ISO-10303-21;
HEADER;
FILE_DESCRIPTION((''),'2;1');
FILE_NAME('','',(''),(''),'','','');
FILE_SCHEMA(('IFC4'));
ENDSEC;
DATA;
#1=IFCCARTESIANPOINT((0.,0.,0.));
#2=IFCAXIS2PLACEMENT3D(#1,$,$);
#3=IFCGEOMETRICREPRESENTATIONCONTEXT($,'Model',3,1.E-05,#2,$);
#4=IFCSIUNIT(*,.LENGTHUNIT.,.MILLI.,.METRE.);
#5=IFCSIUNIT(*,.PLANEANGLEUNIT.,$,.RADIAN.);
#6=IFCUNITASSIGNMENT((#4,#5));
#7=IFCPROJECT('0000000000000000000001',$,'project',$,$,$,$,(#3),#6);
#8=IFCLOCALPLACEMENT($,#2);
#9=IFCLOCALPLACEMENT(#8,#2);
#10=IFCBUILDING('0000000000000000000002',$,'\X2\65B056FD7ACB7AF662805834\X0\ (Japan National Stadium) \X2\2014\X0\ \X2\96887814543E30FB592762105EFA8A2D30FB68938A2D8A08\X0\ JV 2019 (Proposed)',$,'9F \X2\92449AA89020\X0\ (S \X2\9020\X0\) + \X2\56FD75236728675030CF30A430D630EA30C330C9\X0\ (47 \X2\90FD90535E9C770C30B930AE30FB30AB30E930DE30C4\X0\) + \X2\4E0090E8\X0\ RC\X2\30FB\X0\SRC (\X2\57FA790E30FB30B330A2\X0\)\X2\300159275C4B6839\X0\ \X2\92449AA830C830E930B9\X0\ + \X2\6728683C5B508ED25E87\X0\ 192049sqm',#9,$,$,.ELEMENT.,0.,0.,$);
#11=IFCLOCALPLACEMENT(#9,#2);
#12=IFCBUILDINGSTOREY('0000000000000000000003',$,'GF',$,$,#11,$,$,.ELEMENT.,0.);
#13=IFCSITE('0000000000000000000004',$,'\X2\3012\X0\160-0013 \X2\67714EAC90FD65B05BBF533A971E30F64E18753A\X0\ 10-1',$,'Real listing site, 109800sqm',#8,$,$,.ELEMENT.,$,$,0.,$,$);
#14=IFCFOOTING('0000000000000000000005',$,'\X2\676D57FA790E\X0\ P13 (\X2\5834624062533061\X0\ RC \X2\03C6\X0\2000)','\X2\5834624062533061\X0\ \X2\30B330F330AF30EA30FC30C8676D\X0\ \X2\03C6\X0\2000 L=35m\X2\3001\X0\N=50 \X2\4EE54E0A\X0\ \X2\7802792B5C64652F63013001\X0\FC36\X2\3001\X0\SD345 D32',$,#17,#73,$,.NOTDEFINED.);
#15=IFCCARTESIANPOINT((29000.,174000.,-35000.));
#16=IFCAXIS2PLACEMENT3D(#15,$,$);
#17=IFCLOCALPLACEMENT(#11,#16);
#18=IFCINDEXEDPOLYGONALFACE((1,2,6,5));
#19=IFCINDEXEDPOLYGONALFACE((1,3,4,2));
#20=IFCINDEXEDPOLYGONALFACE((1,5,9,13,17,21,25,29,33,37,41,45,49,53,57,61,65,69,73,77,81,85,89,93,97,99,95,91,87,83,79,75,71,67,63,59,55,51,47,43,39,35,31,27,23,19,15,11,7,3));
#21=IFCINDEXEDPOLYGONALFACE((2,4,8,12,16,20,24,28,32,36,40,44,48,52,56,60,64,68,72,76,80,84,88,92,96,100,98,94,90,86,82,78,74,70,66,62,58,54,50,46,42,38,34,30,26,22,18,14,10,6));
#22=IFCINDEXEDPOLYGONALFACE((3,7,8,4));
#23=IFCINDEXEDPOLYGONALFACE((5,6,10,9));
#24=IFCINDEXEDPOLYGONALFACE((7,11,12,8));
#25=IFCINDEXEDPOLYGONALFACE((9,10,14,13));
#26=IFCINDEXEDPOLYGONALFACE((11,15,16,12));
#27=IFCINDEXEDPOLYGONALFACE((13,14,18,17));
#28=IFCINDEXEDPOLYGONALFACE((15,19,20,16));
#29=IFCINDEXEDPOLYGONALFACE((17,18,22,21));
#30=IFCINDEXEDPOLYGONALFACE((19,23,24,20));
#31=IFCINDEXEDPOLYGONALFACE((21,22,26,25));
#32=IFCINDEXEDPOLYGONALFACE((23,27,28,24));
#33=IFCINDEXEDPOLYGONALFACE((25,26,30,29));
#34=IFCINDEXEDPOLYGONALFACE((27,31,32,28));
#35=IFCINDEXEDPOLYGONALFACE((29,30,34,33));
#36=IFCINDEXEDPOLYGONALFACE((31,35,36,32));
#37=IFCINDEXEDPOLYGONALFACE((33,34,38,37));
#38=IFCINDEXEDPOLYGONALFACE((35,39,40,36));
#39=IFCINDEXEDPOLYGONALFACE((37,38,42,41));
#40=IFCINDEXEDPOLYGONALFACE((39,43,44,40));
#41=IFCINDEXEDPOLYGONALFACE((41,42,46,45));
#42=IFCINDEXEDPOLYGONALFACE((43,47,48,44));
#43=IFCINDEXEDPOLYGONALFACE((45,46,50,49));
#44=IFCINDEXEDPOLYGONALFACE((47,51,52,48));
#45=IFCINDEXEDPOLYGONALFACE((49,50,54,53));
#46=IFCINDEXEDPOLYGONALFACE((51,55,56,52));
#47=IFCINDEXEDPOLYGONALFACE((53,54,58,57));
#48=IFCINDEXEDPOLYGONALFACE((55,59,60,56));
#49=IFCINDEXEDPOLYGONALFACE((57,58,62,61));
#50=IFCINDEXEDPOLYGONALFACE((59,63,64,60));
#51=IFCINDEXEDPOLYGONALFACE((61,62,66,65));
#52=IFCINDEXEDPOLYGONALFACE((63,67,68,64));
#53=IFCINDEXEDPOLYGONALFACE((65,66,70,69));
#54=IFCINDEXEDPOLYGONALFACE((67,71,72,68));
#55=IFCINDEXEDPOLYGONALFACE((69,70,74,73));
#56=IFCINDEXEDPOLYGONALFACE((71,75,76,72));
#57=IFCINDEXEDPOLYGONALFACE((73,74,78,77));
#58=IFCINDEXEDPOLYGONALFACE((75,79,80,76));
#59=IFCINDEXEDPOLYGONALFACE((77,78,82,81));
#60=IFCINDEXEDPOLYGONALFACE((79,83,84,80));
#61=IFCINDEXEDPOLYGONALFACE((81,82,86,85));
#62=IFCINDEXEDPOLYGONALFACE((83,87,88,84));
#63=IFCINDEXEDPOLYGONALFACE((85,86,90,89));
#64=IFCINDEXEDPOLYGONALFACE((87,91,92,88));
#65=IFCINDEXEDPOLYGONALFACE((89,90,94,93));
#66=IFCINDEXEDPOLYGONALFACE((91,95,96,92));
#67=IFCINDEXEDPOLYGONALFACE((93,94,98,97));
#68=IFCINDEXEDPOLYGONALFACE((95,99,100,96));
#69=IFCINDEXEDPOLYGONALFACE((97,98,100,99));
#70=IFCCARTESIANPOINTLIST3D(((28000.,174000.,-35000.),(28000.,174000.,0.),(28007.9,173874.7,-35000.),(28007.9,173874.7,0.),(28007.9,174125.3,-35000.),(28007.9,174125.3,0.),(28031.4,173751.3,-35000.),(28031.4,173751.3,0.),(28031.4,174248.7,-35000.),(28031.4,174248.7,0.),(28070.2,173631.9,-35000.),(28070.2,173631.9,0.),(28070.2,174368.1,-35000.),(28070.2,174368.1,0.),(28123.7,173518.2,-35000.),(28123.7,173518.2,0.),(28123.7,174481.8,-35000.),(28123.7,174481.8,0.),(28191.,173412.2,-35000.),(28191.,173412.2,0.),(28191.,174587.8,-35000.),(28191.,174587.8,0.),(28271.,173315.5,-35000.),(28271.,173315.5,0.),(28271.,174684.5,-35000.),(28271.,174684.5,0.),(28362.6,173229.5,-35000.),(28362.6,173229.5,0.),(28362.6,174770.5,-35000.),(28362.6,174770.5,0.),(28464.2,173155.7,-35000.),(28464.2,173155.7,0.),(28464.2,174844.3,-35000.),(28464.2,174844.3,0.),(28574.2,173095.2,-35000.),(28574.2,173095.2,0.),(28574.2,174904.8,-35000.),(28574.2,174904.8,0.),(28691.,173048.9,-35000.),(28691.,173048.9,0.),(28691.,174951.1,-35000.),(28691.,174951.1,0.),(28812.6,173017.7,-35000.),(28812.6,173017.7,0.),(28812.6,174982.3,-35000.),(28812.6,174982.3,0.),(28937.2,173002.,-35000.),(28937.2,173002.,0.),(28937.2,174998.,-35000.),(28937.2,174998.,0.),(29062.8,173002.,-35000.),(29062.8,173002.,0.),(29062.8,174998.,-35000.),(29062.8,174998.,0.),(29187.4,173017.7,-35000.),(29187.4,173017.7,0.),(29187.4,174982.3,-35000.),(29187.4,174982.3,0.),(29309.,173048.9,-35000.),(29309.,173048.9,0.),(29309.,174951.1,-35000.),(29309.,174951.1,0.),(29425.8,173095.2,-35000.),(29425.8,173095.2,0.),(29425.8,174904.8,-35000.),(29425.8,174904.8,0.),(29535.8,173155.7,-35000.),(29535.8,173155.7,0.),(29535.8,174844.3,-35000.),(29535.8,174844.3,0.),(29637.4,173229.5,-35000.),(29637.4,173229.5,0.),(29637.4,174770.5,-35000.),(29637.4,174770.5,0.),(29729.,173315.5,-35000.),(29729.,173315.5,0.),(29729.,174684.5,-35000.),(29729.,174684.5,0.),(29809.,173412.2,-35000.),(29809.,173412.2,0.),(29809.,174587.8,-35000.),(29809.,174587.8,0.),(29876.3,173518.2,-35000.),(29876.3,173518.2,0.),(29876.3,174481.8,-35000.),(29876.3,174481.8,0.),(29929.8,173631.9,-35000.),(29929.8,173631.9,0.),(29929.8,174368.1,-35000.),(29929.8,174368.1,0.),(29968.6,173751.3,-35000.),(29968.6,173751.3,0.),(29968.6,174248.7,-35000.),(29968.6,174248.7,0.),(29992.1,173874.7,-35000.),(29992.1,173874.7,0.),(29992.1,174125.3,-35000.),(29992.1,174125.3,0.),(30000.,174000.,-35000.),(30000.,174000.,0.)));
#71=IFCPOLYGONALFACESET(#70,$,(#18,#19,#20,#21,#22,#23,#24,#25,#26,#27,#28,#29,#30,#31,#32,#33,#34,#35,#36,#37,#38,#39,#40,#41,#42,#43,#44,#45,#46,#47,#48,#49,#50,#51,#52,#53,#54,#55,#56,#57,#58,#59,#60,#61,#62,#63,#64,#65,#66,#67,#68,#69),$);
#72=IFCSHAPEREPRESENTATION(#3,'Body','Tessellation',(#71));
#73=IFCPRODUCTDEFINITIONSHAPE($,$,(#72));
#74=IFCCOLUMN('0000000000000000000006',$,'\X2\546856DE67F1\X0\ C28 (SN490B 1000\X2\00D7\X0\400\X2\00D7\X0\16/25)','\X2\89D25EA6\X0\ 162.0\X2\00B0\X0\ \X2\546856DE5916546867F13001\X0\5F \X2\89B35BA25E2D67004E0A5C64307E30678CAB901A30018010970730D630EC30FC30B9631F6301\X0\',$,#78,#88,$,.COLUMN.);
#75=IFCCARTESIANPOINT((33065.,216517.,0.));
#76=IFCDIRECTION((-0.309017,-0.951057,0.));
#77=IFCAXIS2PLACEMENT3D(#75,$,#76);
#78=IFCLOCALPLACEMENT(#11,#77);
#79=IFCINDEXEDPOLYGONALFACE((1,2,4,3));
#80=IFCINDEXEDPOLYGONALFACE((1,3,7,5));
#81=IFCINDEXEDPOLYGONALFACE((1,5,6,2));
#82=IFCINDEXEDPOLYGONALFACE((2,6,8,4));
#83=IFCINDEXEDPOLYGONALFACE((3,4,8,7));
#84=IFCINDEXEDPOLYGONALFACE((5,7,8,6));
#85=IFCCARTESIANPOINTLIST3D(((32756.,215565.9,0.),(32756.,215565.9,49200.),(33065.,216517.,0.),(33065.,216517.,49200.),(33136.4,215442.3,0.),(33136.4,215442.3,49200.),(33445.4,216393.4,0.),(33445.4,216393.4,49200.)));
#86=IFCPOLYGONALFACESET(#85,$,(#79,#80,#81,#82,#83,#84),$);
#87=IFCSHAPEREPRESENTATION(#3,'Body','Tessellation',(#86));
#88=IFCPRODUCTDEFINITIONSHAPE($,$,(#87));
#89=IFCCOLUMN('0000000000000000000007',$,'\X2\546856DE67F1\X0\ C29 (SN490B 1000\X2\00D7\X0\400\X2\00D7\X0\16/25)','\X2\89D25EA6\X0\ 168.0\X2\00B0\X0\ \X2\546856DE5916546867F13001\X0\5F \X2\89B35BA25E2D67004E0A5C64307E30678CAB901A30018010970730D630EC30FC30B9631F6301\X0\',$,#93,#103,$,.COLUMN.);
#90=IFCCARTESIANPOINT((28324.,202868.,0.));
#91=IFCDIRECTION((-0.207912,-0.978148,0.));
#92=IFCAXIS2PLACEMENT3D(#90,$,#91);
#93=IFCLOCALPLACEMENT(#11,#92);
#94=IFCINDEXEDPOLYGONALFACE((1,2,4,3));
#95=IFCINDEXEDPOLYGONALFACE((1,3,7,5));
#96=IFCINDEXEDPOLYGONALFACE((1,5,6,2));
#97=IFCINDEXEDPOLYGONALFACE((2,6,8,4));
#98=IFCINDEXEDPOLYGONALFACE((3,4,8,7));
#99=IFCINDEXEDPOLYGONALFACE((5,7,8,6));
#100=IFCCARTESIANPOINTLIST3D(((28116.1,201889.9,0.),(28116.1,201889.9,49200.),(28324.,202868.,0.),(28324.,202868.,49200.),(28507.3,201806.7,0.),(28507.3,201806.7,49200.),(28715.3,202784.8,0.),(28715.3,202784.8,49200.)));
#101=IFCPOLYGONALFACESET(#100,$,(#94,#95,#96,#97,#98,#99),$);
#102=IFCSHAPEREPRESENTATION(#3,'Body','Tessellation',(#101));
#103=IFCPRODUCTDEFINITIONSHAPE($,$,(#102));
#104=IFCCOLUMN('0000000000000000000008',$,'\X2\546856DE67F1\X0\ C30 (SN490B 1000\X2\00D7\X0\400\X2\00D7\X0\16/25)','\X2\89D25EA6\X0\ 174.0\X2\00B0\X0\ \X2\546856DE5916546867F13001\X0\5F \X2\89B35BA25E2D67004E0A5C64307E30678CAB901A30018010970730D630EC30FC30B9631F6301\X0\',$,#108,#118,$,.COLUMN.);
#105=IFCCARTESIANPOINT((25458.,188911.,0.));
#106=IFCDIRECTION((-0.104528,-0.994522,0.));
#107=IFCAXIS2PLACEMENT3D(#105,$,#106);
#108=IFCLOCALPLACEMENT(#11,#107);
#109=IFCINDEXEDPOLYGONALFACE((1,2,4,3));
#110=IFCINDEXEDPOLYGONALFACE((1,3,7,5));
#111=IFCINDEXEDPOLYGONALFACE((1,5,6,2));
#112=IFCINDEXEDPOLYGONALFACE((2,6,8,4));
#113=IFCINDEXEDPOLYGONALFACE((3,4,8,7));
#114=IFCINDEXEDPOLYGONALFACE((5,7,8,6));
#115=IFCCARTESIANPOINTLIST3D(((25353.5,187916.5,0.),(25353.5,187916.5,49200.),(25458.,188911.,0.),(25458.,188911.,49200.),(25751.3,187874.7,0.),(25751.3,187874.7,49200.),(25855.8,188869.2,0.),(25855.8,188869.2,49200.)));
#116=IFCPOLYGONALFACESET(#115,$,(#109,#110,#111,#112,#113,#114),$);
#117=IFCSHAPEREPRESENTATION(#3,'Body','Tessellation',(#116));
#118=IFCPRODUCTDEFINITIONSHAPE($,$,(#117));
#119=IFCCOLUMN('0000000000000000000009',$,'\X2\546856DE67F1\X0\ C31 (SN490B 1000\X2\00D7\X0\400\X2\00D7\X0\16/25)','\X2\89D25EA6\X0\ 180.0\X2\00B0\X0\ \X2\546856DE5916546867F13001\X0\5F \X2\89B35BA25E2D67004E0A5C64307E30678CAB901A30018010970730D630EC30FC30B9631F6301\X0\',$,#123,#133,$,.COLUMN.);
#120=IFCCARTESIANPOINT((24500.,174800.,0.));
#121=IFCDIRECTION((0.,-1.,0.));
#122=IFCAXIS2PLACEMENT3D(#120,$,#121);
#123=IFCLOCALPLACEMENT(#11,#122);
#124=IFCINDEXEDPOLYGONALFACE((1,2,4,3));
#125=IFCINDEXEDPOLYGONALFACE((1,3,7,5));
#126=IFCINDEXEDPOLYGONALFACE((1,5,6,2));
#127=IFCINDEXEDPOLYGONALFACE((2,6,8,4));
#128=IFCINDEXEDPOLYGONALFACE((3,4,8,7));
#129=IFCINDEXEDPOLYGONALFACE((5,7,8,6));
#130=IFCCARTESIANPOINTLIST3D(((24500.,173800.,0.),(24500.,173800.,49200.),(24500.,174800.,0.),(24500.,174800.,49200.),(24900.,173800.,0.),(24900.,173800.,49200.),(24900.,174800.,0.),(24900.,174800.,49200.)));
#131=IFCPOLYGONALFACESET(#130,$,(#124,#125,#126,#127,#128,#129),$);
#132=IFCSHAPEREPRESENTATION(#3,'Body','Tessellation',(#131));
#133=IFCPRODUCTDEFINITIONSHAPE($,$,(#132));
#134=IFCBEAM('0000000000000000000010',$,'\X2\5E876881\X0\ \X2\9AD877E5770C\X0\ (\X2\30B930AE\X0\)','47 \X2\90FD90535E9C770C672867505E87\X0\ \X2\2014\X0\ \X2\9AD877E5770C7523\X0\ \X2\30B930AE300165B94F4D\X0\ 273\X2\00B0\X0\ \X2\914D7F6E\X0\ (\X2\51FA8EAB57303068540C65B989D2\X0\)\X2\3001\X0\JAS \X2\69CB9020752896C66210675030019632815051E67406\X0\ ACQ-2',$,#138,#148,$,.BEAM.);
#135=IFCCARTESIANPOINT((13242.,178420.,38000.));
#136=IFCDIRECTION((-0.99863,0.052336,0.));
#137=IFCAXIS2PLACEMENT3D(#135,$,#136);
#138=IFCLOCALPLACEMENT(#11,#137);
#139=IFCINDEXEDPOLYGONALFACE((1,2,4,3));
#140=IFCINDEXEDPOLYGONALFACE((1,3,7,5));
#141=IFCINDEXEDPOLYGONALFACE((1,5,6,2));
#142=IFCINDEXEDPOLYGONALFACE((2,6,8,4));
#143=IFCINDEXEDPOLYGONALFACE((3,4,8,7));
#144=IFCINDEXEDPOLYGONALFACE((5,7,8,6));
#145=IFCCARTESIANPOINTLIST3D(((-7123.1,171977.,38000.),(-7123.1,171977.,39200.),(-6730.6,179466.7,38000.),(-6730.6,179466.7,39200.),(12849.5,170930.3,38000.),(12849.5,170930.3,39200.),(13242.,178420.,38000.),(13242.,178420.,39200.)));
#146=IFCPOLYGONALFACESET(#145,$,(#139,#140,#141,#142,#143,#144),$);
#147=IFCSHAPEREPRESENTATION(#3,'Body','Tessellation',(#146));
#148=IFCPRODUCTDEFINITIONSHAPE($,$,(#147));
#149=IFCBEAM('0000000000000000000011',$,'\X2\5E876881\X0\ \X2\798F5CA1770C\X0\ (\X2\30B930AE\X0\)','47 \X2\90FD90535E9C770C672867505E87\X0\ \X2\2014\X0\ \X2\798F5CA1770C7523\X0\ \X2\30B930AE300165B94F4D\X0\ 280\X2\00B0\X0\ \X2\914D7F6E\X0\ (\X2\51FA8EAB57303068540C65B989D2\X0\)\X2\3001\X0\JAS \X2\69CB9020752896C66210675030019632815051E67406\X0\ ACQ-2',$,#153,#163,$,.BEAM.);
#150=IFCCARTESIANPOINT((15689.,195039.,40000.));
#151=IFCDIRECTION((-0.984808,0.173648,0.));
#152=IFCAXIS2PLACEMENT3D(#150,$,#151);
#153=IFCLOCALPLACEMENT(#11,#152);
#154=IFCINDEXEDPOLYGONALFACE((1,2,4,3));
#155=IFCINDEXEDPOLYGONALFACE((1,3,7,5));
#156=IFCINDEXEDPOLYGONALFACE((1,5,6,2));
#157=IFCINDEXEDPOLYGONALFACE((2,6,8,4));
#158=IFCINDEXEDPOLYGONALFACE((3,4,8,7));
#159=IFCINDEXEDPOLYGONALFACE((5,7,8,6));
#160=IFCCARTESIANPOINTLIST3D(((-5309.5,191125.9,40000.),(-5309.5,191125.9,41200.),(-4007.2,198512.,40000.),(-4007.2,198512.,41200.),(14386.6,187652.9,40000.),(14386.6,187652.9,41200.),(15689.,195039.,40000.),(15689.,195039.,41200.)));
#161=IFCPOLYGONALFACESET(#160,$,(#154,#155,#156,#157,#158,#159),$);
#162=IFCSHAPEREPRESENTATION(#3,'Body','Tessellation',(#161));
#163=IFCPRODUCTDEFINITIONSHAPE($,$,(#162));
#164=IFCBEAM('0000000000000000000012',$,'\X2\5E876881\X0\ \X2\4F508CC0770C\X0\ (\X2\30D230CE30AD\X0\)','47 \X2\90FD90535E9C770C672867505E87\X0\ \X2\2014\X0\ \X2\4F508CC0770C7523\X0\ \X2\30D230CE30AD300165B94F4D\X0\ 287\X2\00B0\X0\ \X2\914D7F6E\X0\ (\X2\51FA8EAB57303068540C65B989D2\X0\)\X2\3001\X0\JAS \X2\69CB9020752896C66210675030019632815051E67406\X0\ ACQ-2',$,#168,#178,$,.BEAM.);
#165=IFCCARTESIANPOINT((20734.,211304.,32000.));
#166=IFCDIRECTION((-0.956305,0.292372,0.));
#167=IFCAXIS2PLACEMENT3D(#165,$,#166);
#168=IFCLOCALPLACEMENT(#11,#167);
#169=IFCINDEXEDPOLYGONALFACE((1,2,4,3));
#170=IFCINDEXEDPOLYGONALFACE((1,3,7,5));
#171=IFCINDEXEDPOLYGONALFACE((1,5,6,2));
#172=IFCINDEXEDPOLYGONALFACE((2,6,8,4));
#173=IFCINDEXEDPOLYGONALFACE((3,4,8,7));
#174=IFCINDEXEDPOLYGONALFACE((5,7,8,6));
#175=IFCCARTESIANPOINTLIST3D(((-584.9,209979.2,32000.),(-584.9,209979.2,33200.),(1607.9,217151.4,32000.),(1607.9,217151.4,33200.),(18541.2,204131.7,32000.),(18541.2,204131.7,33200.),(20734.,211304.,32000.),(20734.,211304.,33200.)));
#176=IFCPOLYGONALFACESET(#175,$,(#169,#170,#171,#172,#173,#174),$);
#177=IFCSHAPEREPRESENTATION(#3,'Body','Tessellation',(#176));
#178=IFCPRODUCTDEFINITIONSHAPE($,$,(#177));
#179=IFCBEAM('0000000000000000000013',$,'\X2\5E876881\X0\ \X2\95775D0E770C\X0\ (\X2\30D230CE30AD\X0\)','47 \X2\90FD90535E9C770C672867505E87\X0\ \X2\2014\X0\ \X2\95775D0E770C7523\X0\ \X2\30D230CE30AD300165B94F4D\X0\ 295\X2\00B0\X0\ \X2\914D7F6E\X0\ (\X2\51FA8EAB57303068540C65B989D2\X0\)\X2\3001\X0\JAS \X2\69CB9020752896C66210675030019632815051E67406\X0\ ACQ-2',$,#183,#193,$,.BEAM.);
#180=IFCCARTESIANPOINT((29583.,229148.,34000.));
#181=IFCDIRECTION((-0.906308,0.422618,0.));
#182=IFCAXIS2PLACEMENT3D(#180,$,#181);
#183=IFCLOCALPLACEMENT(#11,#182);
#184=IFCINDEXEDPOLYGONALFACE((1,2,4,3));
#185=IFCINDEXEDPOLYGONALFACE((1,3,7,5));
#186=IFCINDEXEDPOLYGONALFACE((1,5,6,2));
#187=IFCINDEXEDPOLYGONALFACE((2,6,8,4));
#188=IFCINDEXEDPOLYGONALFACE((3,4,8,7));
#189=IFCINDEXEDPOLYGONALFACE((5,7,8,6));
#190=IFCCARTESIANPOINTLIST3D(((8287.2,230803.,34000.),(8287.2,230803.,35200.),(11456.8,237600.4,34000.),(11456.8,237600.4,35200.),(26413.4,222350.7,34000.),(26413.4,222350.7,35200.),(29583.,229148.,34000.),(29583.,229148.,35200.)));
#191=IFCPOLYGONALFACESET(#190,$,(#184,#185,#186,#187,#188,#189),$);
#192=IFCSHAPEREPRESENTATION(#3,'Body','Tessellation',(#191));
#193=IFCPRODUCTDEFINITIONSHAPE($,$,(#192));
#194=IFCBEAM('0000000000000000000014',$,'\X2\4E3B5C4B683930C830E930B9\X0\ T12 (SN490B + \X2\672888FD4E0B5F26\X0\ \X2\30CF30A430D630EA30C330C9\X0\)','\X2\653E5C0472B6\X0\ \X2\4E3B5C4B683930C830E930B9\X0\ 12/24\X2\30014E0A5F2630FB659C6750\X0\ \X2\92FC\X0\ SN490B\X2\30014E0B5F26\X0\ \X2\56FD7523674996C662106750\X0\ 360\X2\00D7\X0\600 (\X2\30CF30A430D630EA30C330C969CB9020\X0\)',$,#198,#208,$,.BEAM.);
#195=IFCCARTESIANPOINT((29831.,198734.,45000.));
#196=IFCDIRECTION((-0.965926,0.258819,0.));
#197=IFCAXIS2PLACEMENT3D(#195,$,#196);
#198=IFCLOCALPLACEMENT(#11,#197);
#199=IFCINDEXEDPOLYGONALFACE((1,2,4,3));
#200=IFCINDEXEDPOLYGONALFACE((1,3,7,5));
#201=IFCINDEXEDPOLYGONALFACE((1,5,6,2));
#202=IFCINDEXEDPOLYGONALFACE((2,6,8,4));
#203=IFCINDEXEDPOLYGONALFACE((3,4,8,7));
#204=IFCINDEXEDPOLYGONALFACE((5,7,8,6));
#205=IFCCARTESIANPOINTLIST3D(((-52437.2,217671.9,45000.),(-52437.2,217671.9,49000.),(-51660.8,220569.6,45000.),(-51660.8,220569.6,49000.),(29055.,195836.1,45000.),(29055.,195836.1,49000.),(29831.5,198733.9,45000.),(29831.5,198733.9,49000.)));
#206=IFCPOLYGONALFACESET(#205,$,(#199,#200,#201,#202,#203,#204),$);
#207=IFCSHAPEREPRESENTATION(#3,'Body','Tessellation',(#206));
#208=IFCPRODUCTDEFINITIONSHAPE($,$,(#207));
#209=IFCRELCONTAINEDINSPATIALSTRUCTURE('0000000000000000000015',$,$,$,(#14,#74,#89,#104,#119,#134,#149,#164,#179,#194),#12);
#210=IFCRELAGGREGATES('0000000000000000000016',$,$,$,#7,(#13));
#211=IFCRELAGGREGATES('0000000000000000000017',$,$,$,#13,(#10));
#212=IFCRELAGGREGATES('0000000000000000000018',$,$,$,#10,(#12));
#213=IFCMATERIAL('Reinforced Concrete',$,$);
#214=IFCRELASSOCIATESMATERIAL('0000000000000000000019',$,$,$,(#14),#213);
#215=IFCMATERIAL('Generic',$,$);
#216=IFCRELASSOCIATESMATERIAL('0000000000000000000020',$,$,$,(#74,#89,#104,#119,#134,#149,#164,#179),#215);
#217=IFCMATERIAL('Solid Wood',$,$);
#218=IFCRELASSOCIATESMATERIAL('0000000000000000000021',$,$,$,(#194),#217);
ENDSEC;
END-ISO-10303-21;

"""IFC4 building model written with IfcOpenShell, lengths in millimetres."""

from ifc_helpers import new_model, si_unit, frame, frame_2d, origin, origin_2d, place, context, project, spatial, rectangle, circle, extrude, material, element, save


model = new_model("IFC4")

# Units and contexts
model_context = context("Model", 3, precision=1e-05, world=origin())
ifc_project = project(units=[si_unit("LENGTHUNIT", "METRE", prefix="MILLI"), si_unit("PLANEANGLEUNIT", "RADIAN")], contexts=[model_context])

# Site, building, storey
site_placement = place(None, origin())
site = spatial("IfcSite", under=ifc_project, at=site_placement, Name="〒160-0013 東京都新宿区霞ヶ丘町 10-1", ObjectType="Real listing site, 109800sqm", CompositionType="ELEMENT", RefElevation=0.0)
building_placement = place(site_placement, origin())
building = spatial("IfcBuilding", under=site, at=building_placement, Name="新国立競技場 (Japan National Stadium) — 隈研吾・大成建設・梓設計 JV 2019 (Proposed)", ObjectType="9F 鉄骨造 (S 造) + 国産木材ハイブリッド (47 都道府県スギ・カラマツ) + 一部 RC・SRC (基礎・コア)、大屋根 鉄骨トラス + 木格子軒庇 192049sqm", CompositionType="ELEMENT", ElevationOfRefHeight=0.0, ElevationOfTerrain=0.0)
storey_placement = place(building_placement, origin())
storey = spatial("IfcBuildingStorey", under=building, at=storey_placement, Name="GF", CompositionType="ELEMENT", Elevation=0.0)

# Footing
ifc_material_1 = material(Name="Reinforced Concrete")
footing_placement = place(storey_placement, frame((29000.0, 174000.0, -35000.0)))
element("IfcFooting", 1, at=footing_placement, inside=storey, material=ifc_material_1, Name="杭基礎 P13 (場所打ち RC φ2000)", Description="場所打ち コンクリート杭 φ2000 L=35m、N=50 以上 砂礫層支持、FC36、SD345 D32", PredefinedType="NOTDEFINED", context=model_context, shape_type="SweptSolid", body=[
    extrude(circle(Radius=1000.0, at=origin_2d()), frame((29000.0, 174000.0, -35000.0)), (0.0, 0.0, 1.0), 35000.0),
])

# Columns
ifc_material_2 = material(Name="Generic")
column_1_placement = place(storey_placement, frame((33065.0, 216517.0, 0.0), x_axis=(-0.309017, -0.951057, 0.0)))
element("IfcColumn", 2, at=column_1_placement, inside=storey, material=ifc_material_2, Name="周回柱 C28 (SN490B 1000×400×16/25)", Description="角度 162.0° 周回外周柱、5F 観客席最上層まで貫通、耐震ブレース挟持", PredefinedType="COLUMN", context=model_context, shape_type="SweptSolid", body=[
    extrude(rectangle(XDim=1000.0, YDim=400.0, at=frame_2d((500.0, 200.0))), frame((33065.0, 216517.0, 0.0), x_axis=(-0.309017, -0.951057, 0.0)), (0.0, 0.0, 1.0), 49200.0),
])
column_2_placement = place(storey_placement, frame((28324.0, 202868.0, 0.0), x_axis=(-0.207912, -0.978148, 0.0)))
element("IfcColumn", 3, at=column_2_placement, inside=storey, material=ifc_material_2, Name="周回柱 C29 (SN490B 1000×400×16/25)", Description="角度 168.0° 周回外周柱、5F 観客席最上層まで貫通、耐震ブレース挟持", PredefinedType="COLUMN", context=model_context, shape_type="SweptSolid", body=[
    extrude(rectangle(XDim=1000.0, YDim=400.0, at=frame_2d((500.0, 200.0))), frame((28324.0, 202868.0, 0.0), x_axis=(-0.207912, -0.978148, 0.0)), (0.0, 0.0, 1.0), 49200.0),
])
column_3_placement = place(storey_placement, frame((25458.0, 188911.0, 0.0), x_axis=(-0.104528, -0.994522, 0.0)))
element("IfcColumn", 4, at=column_3_placement, inside=storey, material=ifc_material_2, Name="周回柱 C30 (SN490B 1000×400×16/25)", Description="角度 174.0° 周回外周柱、5F 観客席最上層まで貫通、耐震ブレース挟持", PredefinedType="COLUMN", context=model_context, shape_type="SweptSolid", body=[
    extrude(rectangle(XDim=1000.0, YDim=400.0, at=frame_2d((500.0, 200.0))), frame((25458.0, 188911.0, 0.0), x_axis=(-0.104528, -0.994522, 0.0)), (0.0, 0.0, 1.0), 49200.0),
])
column_4_placement = place(storey_placement, frame((24500.0, 174800.0, 0.0), x_axis=(0.0, -1.0, 0.0)))
element("IfcColumn", 5, at=column_4_placement, inside=storey, material=ifc_material_2, Name="周回柱 C31 (SN490B 1000×400×16/25)", Description="角度 180.0° 周回外周柱、5F 観客席最上層まで貫通、耐震ブレース挟持", PredefinedType="COLUMN", context=model_context, shape_type="SweptSolid", body=[
    extrude(rectangle(XDim=1000.0, YDim=400.0, at=frame_2d((500.0, 200.0))), frame((24500.0, 174800.0, 0.0), x_axis=(0.0, -1.0, 0.0)), (0.0, 0.0, 1.0), 49200.0),
])

# Beams
beam_1_placement = place(storey_placement, frame((13242.0, 178420.0, 38000.0), x_axis=(-0.99863, 0.052336, 0.0)))
element("IfcBeam", 6, at=beam_1_placement, inside=storey, material=ifc_material_2, Name="庇梁 高知県 (スギ)", Description="47 都道府県木材庇 — 高知県産 スギ、方位 273° 配置 (出身地と同方角)、JAS 構造用集成材、防腐処理 ACQ-2", PredefinedType="BEAM", context=model_context, shape_type="SweptSolid", body=[
    extrude(rectangle(XDim=20000.0, YDim=7500.0, at=frame_2d((10000.0, 3750.0))), frame((13242.0, 178420.0, 38000.0), x_axis=(-0.99863, 0.052336, 0.0)), (0.0, 0.0, 1.0), 1200.0),
])
beam_2_placement = place(storey_placement, frame((15689.0, 195039.0, 40000.0), x_axis=(-0.984808, 0.173648, 0.0)))
element("IfcBeam", 7, at=beam_2_placement, inside=storey, material=ifc_material_2, Name="庇梁 福岡県 (スギ)", Description="47 都道府県木材庇 — 福岡県産 スギ、方位 280° 配置 (出身地と同方角)、JAS 構造用集成材、防腐処理 ACQ-2", PredefinedType="BEAM", context=model_context, shape_type="SweptSolid", body=[
    extrude(rectangle(XDim=20000.0, YDim=7500.0, at=frame_2d((10000.0, 3750.0))), frame((15689.0, 195039.0, 40000.0), x_axis=(-0.984808, 0.173648, 0.0)), (0.0, 0.0, 1.0), 1200.0),
])
beam_3_placement = place(storey_placement, frame((20734.0, 211304.0, 32000.0), x_axis=(-0.956305, 0.292372, 0.0)))
element("IfcBeam", 8, at=beam_3_placement, inside=storey, material=ifc_material_2, Name="庇梁 佐賀県 (ヒノキ)", Description="47 都道府県木材庇 — 佐賀県産 ヒノキ、方位 287° 配置 (出身地と同方角)、JAS 構造用集成材、防腐処理 ACQ-2", PredefinedType="BEAM", context=model_context, shape_type="SweptSolid", body=[
    extrude(rectangle(XDim=20000.0, YDim=7500.0, at=frame_2d((10000.0, 3750.0))), frame((20734.0, 211304.0, 32000.0), x_axis=(-0.956305, 0.292372, 0.0)), (0.0, 0.0, 1.0), 1200.0),
])
beam_4_placement = place(storey_placement, frame((29583.0, 229148.0, 34000.0), x_axis=(-0.906308, 0.422618, 0.0)))
element("IfcBeam", 9, at=beam_4_placement, inside=storey, material=ifc_material_2, Name="庇梁 長崎県 (ヒノキ)", Description="47 都道府県木材庇 — 長崎県産 ヒノキ、方位 295° 配置 (出身地と同方角)、JAS 構造用集成材、防腐処理 ACQ-2", PredefinedType="BEAM", context=model_context, shape_type="SweptSolid", body=[
    extrude(rectangle(XDim=20000.0, YDim=7500.0, at=frame_2d((10000.0, 3750.0))), frame((29583.0, 229148.0, 34000.0), x_axis=(-0.906308, 0.422618, 0.0)), (0.0, 0.0, 1.0), 1200.0),
])
ifc_material_3 = material(Name="Solid Wood")
beam_5_placement = place(storey_placement, frame((29831.0, 198734.0, 45000.0), x_axis=(-0.965926, 0.258819, 0.0)))
element("IfcBeam", 10, at=beam_5_placement, inside=storey, material=ifc_material_3, Name="主屋根トラス T12 (SN490B + 木製下弦 ハイブリッド)", Description="放射状 主屋根トラス 12/24、上弦・斜材 鋼 SN490B、下弦 国産杉集成材 360×600 (ハイブリッド構造)", PredefinedType="BEAM", context=model_context, shape_type="SweptSolid", body=[
    extrude(rectangle(XDim=84367.0, YDim=3000.0, at=frame_2d((42183.0, 1500.0))), frame((29831.0, 198734.0, 45000.0), x_axis=(-0.965926, 0.258819, 0.0)), (0.0, 0.0, 1.0), 4000.0),
])

save(model, "model.ifc")
